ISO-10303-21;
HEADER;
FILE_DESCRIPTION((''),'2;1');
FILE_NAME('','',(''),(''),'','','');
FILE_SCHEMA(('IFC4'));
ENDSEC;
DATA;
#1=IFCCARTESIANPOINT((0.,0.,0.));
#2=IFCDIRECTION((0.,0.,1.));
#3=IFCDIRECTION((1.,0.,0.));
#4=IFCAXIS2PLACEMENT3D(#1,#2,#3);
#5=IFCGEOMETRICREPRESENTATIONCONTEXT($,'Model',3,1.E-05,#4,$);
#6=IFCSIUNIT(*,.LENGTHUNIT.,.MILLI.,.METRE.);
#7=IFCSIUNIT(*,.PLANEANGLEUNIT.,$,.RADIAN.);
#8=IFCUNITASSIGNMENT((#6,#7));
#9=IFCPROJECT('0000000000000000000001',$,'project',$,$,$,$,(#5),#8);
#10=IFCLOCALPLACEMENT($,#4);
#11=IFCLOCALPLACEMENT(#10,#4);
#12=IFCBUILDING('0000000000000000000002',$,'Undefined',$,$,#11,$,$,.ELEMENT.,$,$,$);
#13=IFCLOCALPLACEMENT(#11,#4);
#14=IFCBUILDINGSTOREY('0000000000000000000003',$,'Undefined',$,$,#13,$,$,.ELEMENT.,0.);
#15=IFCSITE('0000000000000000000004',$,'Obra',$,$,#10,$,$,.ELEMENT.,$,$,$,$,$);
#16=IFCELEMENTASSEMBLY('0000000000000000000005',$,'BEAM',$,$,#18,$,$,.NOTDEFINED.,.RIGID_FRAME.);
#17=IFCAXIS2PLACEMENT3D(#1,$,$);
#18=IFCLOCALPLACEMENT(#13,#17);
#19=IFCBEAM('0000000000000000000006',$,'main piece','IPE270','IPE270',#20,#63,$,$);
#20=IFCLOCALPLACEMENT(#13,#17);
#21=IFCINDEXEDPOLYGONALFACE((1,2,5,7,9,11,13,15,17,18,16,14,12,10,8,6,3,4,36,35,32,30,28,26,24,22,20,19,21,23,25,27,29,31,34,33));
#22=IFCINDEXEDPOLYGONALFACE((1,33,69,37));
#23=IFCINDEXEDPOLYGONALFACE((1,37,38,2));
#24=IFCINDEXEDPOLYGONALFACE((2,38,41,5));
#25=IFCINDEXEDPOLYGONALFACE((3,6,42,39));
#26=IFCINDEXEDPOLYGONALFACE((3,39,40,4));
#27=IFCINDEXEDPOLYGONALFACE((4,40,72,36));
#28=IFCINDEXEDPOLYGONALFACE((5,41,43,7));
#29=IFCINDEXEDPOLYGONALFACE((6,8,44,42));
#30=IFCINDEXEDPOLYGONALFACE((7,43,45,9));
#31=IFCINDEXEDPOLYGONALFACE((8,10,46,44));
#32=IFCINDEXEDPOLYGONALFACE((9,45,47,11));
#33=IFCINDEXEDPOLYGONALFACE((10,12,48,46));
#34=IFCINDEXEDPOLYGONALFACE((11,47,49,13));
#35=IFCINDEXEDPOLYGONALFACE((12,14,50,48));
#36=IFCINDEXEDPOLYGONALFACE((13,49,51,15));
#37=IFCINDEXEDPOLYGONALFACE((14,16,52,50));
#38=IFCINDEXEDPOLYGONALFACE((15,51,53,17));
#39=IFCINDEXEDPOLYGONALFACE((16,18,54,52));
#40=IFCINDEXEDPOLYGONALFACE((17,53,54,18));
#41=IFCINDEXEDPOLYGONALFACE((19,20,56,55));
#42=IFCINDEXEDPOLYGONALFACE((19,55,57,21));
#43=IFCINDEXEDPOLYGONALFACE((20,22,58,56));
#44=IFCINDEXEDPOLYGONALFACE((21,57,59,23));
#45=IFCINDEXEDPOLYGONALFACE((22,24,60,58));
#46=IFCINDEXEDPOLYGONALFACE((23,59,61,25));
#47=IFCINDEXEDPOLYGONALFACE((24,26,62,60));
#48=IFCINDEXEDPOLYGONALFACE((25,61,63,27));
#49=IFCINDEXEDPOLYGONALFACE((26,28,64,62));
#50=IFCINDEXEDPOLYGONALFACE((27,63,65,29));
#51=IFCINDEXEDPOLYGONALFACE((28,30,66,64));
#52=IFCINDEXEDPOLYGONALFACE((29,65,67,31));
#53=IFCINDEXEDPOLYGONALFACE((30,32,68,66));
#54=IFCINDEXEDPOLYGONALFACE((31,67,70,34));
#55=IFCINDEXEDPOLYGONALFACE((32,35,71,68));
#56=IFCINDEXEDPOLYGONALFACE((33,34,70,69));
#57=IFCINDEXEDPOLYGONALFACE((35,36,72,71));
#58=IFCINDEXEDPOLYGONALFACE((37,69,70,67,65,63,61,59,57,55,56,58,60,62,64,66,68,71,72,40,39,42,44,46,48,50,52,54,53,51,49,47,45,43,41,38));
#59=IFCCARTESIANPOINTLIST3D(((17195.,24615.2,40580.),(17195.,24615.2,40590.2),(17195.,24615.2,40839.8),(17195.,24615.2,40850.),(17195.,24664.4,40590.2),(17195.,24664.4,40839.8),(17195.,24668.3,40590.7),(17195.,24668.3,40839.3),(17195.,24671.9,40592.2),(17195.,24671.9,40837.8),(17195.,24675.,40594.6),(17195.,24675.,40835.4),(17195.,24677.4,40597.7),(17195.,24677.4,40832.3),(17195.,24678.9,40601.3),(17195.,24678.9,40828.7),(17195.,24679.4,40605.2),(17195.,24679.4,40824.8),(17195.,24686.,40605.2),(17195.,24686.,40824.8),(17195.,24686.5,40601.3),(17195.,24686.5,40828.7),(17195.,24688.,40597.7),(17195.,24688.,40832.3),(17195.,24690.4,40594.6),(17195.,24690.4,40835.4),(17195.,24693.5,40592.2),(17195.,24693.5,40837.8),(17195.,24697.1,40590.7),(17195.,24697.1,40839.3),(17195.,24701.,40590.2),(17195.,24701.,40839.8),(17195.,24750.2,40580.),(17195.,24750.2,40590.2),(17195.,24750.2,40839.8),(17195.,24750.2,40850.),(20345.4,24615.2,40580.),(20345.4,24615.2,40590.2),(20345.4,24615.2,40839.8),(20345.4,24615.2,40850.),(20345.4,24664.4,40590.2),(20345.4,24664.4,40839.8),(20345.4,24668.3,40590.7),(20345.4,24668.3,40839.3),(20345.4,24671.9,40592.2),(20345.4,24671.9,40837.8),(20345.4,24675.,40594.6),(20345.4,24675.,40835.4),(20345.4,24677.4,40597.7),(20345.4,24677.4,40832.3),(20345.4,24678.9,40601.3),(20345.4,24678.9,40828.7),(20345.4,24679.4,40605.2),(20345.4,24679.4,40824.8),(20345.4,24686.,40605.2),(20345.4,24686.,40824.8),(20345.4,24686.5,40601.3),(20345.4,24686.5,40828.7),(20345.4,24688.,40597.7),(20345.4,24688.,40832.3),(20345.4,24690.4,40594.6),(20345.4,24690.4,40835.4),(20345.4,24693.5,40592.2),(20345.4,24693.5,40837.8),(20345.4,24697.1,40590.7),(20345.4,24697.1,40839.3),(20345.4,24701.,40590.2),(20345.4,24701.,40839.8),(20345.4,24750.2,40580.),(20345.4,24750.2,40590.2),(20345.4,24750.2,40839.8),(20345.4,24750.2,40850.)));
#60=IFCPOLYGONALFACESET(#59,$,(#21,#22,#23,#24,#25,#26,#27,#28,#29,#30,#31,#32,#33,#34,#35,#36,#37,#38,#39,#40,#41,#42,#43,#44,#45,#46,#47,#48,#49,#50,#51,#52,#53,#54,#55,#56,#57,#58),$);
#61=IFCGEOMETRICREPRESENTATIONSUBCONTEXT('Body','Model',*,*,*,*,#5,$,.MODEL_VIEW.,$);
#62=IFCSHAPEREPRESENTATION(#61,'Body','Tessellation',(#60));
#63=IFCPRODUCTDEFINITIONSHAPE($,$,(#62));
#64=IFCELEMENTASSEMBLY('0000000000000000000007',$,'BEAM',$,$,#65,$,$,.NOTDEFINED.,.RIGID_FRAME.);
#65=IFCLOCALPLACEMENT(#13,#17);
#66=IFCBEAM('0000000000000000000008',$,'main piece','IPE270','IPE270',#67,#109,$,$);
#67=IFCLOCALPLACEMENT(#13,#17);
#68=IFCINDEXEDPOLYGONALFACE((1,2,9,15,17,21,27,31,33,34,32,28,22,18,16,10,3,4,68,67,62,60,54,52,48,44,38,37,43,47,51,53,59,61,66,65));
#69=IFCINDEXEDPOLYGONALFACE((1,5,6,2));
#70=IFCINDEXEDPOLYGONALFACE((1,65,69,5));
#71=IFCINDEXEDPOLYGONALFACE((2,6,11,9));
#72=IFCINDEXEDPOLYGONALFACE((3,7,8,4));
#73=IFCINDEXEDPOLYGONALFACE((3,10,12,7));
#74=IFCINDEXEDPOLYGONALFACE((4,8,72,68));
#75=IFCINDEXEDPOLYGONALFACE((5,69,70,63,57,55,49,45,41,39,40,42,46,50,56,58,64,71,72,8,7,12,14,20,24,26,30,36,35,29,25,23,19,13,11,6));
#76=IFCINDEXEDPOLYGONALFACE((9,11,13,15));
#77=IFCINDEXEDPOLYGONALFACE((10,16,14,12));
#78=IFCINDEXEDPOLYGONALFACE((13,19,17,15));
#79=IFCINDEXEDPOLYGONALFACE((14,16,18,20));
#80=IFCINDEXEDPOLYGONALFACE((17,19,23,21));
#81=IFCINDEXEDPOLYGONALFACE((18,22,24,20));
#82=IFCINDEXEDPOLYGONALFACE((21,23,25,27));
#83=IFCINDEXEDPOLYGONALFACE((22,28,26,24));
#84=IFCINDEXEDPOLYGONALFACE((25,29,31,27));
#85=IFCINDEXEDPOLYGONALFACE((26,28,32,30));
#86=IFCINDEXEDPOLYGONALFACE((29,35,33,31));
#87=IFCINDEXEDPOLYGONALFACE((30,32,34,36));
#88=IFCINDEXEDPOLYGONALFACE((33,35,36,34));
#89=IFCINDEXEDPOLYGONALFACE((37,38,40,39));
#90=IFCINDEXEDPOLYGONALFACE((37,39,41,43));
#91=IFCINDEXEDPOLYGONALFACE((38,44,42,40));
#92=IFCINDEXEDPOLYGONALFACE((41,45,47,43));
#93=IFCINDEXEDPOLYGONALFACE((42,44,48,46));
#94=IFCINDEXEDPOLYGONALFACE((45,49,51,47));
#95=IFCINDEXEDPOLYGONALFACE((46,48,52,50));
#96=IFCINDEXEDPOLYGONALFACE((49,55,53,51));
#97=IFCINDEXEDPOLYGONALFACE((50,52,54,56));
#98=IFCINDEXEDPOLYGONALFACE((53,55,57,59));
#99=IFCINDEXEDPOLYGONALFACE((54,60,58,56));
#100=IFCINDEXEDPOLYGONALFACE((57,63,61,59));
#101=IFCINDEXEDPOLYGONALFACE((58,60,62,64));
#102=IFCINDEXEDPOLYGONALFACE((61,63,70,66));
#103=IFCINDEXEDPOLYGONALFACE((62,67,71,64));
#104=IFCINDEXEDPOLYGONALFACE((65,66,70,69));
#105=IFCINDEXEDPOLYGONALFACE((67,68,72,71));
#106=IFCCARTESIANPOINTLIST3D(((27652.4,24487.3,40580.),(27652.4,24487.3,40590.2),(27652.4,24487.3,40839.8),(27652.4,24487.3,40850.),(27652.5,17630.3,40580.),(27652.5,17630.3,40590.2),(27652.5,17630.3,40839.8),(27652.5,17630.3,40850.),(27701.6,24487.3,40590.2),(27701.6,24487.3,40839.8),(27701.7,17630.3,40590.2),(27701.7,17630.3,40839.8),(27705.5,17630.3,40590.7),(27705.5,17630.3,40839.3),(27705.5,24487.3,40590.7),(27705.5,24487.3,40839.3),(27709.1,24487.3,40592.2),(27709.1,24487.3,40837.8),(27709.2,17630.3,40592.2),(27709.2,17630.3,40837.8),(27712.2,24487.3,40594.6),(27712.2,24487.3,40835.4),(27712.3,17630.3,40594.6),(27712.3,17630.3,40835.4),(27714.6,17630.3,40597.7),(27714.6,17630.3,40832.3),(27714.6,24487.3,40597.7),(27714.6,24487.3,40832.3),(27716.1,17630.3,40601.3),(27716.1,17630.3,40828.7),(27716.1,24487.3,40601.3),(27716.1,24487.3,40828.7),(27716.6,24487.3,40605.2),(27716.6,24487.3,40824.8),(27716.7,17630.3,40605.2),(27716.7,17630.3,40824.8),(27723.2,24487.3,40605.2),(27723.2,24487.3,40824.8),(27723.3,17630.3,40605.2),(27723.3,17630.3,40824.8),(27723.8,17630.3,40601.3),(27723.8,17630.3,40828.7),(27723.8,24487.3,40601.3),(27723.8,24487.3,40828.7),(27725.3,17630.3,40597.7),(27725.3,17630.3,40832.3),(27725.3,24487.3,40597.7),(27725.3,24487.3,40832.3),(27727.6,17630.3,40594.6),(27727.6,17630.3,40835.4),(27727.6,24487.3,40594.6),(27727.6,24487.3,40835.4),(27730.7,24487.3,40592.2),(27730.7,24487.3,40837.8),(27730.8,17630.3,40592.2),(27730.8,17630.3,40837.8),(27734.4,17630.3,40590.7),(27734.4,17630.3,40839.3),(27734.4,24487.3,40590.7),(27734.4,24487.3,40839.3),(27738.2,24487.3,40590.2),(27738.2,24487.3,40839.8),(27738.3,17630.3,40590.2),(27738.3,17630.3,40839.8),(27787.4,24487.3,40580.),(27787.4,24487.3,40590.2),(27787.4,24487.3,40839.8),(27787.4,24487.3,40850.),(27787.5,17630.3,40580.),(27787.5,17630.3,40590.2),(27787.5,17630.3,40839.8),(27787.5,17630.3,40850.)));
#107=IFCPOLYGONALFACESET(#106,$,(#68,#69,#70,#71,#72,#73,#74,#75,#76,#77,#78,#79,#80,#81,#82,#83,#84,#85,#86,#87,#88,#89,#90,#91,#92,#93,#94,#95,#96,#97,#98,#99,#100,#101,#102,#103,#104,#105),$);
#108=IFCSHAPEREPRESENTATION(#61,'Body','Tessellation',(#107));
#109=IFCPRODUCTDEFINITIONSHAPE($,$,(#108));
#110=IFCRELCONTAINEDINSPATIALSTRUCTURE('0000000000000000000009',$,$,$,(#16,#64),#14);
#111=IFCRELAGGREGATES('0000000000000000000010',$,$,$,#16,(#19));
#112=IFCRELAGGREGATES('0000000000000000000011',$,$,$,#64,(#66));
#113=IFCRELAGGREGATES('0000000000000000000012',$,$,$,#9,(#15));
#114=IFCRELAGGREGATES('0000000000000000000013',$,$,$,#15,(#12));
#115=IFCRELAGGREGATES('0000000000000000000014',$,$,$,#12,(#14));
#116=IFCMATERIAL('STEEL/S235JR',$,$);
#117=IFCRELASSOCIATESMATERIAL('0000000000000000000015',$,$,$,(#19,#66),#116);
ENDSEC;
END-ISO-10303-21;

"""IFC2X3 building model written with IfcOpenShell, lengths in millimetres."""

from ifc_helpers import new_model, si_unit, frame, origin_with_axes, origin_2d_with_axis, place, context, subcontext, project, spatial, i_section, extrude, material, element, aggregate, save


model = new_model("IFC2X3")

# Units and contexts
model_context = context("Model", 3, precision=1e-05, world=origin_with_axes())
body_context = subcontext(model_context, "Body", "Model", "MODEL_VIEW")
ifc_project = project(units=[si_unit("LENGTHUNIT", "METRE", prefix="MILLI"), si_unit("PLANEANGLEUNIT", "RADIAN")], contexts=[model_context])

# Site, building, storey
site_placement = place(None, origin_with_axes())
site = spatial("IfcSite", under=ifc_project, at=site_placement, Name="Obra", CompositionType="ELEMENT")
building_placement = place(site_placement, origin_with_axes())
building = spatial("IfcBuilding", under=site, at=building_placement, Name="Undefined", CompositionType="ELEMENT")
storey_placement = place(building_placement, origin_with_axes())
storey = spatial("IfcBuildingStorey", under=building, at=storey_placement, Name="Undefined", CompositionType="ELEMENT", Elevation=0.0)

# Shared definitions
ifc_material_1 = material(Name="STEEL/S235JR")

# Element assemblies, beams
assembly_1_placement = place(storey_placement, origin_with_axes())
assembly_1 = element("IfcElementAssembly", 1, at=assembly_1_placement, inside=storey, Name="BEAM", AssemblyPlace="NOTDEFINED", PredefinedType="RIGID_FRAME")
beam_1_placement = place(assembly_1_placement, frame((17195.0, 24682.7, 40715.0), z_axis=(0.0, 0.0, 1.0), x_axis=(1.0, 0.0, 0.0)))
beam_1 = element("IfcBeam", 2, at=beam_1_placement, material=ifc_material_1, Name="main piece", Description="IPE270", ObjectType="IPE270", context=body_context, shape_type="SweptSolid", body=[
    extrude(i_section(OverallWidth=135.0, OverallDepth=270.0, WebThickness=6.6, FlangeThickness=10.2, FilletRadius=15.0, at=origin_2d_with_axis()), frame((3150.4, 0.0, 0.0), z_axis=(-1.0, 0.0, 0.0), x_axis=(0.0, -1.0, 0.0)), (0.0, 0.0, 1.0), 3150.4),
])
aggregate(assembly_1, [beam_1])
assembly_2_placement = place(storey_placement, origin_with_axes())
assembly_2 = element("IfcElementAssembly", 3, at=assembly_2_placement, inside=storey, Name="BEAM", AssemblyPlace="NOTDEFINED", PredefinedType="RIGID_FRAME")
beam_2_placement = place(assembly_2_placement, frame((27720.0, 17630.3, 40715.0), z_axis=(0.0, 0.0, 1.0), x_axis=(-0.000002, 1.0, 0.0)))
beam_2 = element("IfcBeam", 4, at=beam_2_placement, material=ifc_material_1, Name="main piece", Description="IPE270", ObjectType="IPE270", context=body_context, shape_type="SweptSolid", body=[
    extrude(i_section(OverallWidth=135.0, OverallDepth=270.0, WebThickness=6.6, FlangeThickness=10.2, FilletRadius=15.0, at=origin_2d_with_axis()), frame((6857.0, 0.0, 0.0), z_axis=(-1.0, 0.0, 0.0), x_axis=(0.0, -1.0, 0.0)), (0.0, 0.0, 1.0), 6857.0),
])
aggregate(assembly_2, [beam_2])

save(model, "model.ifc")
